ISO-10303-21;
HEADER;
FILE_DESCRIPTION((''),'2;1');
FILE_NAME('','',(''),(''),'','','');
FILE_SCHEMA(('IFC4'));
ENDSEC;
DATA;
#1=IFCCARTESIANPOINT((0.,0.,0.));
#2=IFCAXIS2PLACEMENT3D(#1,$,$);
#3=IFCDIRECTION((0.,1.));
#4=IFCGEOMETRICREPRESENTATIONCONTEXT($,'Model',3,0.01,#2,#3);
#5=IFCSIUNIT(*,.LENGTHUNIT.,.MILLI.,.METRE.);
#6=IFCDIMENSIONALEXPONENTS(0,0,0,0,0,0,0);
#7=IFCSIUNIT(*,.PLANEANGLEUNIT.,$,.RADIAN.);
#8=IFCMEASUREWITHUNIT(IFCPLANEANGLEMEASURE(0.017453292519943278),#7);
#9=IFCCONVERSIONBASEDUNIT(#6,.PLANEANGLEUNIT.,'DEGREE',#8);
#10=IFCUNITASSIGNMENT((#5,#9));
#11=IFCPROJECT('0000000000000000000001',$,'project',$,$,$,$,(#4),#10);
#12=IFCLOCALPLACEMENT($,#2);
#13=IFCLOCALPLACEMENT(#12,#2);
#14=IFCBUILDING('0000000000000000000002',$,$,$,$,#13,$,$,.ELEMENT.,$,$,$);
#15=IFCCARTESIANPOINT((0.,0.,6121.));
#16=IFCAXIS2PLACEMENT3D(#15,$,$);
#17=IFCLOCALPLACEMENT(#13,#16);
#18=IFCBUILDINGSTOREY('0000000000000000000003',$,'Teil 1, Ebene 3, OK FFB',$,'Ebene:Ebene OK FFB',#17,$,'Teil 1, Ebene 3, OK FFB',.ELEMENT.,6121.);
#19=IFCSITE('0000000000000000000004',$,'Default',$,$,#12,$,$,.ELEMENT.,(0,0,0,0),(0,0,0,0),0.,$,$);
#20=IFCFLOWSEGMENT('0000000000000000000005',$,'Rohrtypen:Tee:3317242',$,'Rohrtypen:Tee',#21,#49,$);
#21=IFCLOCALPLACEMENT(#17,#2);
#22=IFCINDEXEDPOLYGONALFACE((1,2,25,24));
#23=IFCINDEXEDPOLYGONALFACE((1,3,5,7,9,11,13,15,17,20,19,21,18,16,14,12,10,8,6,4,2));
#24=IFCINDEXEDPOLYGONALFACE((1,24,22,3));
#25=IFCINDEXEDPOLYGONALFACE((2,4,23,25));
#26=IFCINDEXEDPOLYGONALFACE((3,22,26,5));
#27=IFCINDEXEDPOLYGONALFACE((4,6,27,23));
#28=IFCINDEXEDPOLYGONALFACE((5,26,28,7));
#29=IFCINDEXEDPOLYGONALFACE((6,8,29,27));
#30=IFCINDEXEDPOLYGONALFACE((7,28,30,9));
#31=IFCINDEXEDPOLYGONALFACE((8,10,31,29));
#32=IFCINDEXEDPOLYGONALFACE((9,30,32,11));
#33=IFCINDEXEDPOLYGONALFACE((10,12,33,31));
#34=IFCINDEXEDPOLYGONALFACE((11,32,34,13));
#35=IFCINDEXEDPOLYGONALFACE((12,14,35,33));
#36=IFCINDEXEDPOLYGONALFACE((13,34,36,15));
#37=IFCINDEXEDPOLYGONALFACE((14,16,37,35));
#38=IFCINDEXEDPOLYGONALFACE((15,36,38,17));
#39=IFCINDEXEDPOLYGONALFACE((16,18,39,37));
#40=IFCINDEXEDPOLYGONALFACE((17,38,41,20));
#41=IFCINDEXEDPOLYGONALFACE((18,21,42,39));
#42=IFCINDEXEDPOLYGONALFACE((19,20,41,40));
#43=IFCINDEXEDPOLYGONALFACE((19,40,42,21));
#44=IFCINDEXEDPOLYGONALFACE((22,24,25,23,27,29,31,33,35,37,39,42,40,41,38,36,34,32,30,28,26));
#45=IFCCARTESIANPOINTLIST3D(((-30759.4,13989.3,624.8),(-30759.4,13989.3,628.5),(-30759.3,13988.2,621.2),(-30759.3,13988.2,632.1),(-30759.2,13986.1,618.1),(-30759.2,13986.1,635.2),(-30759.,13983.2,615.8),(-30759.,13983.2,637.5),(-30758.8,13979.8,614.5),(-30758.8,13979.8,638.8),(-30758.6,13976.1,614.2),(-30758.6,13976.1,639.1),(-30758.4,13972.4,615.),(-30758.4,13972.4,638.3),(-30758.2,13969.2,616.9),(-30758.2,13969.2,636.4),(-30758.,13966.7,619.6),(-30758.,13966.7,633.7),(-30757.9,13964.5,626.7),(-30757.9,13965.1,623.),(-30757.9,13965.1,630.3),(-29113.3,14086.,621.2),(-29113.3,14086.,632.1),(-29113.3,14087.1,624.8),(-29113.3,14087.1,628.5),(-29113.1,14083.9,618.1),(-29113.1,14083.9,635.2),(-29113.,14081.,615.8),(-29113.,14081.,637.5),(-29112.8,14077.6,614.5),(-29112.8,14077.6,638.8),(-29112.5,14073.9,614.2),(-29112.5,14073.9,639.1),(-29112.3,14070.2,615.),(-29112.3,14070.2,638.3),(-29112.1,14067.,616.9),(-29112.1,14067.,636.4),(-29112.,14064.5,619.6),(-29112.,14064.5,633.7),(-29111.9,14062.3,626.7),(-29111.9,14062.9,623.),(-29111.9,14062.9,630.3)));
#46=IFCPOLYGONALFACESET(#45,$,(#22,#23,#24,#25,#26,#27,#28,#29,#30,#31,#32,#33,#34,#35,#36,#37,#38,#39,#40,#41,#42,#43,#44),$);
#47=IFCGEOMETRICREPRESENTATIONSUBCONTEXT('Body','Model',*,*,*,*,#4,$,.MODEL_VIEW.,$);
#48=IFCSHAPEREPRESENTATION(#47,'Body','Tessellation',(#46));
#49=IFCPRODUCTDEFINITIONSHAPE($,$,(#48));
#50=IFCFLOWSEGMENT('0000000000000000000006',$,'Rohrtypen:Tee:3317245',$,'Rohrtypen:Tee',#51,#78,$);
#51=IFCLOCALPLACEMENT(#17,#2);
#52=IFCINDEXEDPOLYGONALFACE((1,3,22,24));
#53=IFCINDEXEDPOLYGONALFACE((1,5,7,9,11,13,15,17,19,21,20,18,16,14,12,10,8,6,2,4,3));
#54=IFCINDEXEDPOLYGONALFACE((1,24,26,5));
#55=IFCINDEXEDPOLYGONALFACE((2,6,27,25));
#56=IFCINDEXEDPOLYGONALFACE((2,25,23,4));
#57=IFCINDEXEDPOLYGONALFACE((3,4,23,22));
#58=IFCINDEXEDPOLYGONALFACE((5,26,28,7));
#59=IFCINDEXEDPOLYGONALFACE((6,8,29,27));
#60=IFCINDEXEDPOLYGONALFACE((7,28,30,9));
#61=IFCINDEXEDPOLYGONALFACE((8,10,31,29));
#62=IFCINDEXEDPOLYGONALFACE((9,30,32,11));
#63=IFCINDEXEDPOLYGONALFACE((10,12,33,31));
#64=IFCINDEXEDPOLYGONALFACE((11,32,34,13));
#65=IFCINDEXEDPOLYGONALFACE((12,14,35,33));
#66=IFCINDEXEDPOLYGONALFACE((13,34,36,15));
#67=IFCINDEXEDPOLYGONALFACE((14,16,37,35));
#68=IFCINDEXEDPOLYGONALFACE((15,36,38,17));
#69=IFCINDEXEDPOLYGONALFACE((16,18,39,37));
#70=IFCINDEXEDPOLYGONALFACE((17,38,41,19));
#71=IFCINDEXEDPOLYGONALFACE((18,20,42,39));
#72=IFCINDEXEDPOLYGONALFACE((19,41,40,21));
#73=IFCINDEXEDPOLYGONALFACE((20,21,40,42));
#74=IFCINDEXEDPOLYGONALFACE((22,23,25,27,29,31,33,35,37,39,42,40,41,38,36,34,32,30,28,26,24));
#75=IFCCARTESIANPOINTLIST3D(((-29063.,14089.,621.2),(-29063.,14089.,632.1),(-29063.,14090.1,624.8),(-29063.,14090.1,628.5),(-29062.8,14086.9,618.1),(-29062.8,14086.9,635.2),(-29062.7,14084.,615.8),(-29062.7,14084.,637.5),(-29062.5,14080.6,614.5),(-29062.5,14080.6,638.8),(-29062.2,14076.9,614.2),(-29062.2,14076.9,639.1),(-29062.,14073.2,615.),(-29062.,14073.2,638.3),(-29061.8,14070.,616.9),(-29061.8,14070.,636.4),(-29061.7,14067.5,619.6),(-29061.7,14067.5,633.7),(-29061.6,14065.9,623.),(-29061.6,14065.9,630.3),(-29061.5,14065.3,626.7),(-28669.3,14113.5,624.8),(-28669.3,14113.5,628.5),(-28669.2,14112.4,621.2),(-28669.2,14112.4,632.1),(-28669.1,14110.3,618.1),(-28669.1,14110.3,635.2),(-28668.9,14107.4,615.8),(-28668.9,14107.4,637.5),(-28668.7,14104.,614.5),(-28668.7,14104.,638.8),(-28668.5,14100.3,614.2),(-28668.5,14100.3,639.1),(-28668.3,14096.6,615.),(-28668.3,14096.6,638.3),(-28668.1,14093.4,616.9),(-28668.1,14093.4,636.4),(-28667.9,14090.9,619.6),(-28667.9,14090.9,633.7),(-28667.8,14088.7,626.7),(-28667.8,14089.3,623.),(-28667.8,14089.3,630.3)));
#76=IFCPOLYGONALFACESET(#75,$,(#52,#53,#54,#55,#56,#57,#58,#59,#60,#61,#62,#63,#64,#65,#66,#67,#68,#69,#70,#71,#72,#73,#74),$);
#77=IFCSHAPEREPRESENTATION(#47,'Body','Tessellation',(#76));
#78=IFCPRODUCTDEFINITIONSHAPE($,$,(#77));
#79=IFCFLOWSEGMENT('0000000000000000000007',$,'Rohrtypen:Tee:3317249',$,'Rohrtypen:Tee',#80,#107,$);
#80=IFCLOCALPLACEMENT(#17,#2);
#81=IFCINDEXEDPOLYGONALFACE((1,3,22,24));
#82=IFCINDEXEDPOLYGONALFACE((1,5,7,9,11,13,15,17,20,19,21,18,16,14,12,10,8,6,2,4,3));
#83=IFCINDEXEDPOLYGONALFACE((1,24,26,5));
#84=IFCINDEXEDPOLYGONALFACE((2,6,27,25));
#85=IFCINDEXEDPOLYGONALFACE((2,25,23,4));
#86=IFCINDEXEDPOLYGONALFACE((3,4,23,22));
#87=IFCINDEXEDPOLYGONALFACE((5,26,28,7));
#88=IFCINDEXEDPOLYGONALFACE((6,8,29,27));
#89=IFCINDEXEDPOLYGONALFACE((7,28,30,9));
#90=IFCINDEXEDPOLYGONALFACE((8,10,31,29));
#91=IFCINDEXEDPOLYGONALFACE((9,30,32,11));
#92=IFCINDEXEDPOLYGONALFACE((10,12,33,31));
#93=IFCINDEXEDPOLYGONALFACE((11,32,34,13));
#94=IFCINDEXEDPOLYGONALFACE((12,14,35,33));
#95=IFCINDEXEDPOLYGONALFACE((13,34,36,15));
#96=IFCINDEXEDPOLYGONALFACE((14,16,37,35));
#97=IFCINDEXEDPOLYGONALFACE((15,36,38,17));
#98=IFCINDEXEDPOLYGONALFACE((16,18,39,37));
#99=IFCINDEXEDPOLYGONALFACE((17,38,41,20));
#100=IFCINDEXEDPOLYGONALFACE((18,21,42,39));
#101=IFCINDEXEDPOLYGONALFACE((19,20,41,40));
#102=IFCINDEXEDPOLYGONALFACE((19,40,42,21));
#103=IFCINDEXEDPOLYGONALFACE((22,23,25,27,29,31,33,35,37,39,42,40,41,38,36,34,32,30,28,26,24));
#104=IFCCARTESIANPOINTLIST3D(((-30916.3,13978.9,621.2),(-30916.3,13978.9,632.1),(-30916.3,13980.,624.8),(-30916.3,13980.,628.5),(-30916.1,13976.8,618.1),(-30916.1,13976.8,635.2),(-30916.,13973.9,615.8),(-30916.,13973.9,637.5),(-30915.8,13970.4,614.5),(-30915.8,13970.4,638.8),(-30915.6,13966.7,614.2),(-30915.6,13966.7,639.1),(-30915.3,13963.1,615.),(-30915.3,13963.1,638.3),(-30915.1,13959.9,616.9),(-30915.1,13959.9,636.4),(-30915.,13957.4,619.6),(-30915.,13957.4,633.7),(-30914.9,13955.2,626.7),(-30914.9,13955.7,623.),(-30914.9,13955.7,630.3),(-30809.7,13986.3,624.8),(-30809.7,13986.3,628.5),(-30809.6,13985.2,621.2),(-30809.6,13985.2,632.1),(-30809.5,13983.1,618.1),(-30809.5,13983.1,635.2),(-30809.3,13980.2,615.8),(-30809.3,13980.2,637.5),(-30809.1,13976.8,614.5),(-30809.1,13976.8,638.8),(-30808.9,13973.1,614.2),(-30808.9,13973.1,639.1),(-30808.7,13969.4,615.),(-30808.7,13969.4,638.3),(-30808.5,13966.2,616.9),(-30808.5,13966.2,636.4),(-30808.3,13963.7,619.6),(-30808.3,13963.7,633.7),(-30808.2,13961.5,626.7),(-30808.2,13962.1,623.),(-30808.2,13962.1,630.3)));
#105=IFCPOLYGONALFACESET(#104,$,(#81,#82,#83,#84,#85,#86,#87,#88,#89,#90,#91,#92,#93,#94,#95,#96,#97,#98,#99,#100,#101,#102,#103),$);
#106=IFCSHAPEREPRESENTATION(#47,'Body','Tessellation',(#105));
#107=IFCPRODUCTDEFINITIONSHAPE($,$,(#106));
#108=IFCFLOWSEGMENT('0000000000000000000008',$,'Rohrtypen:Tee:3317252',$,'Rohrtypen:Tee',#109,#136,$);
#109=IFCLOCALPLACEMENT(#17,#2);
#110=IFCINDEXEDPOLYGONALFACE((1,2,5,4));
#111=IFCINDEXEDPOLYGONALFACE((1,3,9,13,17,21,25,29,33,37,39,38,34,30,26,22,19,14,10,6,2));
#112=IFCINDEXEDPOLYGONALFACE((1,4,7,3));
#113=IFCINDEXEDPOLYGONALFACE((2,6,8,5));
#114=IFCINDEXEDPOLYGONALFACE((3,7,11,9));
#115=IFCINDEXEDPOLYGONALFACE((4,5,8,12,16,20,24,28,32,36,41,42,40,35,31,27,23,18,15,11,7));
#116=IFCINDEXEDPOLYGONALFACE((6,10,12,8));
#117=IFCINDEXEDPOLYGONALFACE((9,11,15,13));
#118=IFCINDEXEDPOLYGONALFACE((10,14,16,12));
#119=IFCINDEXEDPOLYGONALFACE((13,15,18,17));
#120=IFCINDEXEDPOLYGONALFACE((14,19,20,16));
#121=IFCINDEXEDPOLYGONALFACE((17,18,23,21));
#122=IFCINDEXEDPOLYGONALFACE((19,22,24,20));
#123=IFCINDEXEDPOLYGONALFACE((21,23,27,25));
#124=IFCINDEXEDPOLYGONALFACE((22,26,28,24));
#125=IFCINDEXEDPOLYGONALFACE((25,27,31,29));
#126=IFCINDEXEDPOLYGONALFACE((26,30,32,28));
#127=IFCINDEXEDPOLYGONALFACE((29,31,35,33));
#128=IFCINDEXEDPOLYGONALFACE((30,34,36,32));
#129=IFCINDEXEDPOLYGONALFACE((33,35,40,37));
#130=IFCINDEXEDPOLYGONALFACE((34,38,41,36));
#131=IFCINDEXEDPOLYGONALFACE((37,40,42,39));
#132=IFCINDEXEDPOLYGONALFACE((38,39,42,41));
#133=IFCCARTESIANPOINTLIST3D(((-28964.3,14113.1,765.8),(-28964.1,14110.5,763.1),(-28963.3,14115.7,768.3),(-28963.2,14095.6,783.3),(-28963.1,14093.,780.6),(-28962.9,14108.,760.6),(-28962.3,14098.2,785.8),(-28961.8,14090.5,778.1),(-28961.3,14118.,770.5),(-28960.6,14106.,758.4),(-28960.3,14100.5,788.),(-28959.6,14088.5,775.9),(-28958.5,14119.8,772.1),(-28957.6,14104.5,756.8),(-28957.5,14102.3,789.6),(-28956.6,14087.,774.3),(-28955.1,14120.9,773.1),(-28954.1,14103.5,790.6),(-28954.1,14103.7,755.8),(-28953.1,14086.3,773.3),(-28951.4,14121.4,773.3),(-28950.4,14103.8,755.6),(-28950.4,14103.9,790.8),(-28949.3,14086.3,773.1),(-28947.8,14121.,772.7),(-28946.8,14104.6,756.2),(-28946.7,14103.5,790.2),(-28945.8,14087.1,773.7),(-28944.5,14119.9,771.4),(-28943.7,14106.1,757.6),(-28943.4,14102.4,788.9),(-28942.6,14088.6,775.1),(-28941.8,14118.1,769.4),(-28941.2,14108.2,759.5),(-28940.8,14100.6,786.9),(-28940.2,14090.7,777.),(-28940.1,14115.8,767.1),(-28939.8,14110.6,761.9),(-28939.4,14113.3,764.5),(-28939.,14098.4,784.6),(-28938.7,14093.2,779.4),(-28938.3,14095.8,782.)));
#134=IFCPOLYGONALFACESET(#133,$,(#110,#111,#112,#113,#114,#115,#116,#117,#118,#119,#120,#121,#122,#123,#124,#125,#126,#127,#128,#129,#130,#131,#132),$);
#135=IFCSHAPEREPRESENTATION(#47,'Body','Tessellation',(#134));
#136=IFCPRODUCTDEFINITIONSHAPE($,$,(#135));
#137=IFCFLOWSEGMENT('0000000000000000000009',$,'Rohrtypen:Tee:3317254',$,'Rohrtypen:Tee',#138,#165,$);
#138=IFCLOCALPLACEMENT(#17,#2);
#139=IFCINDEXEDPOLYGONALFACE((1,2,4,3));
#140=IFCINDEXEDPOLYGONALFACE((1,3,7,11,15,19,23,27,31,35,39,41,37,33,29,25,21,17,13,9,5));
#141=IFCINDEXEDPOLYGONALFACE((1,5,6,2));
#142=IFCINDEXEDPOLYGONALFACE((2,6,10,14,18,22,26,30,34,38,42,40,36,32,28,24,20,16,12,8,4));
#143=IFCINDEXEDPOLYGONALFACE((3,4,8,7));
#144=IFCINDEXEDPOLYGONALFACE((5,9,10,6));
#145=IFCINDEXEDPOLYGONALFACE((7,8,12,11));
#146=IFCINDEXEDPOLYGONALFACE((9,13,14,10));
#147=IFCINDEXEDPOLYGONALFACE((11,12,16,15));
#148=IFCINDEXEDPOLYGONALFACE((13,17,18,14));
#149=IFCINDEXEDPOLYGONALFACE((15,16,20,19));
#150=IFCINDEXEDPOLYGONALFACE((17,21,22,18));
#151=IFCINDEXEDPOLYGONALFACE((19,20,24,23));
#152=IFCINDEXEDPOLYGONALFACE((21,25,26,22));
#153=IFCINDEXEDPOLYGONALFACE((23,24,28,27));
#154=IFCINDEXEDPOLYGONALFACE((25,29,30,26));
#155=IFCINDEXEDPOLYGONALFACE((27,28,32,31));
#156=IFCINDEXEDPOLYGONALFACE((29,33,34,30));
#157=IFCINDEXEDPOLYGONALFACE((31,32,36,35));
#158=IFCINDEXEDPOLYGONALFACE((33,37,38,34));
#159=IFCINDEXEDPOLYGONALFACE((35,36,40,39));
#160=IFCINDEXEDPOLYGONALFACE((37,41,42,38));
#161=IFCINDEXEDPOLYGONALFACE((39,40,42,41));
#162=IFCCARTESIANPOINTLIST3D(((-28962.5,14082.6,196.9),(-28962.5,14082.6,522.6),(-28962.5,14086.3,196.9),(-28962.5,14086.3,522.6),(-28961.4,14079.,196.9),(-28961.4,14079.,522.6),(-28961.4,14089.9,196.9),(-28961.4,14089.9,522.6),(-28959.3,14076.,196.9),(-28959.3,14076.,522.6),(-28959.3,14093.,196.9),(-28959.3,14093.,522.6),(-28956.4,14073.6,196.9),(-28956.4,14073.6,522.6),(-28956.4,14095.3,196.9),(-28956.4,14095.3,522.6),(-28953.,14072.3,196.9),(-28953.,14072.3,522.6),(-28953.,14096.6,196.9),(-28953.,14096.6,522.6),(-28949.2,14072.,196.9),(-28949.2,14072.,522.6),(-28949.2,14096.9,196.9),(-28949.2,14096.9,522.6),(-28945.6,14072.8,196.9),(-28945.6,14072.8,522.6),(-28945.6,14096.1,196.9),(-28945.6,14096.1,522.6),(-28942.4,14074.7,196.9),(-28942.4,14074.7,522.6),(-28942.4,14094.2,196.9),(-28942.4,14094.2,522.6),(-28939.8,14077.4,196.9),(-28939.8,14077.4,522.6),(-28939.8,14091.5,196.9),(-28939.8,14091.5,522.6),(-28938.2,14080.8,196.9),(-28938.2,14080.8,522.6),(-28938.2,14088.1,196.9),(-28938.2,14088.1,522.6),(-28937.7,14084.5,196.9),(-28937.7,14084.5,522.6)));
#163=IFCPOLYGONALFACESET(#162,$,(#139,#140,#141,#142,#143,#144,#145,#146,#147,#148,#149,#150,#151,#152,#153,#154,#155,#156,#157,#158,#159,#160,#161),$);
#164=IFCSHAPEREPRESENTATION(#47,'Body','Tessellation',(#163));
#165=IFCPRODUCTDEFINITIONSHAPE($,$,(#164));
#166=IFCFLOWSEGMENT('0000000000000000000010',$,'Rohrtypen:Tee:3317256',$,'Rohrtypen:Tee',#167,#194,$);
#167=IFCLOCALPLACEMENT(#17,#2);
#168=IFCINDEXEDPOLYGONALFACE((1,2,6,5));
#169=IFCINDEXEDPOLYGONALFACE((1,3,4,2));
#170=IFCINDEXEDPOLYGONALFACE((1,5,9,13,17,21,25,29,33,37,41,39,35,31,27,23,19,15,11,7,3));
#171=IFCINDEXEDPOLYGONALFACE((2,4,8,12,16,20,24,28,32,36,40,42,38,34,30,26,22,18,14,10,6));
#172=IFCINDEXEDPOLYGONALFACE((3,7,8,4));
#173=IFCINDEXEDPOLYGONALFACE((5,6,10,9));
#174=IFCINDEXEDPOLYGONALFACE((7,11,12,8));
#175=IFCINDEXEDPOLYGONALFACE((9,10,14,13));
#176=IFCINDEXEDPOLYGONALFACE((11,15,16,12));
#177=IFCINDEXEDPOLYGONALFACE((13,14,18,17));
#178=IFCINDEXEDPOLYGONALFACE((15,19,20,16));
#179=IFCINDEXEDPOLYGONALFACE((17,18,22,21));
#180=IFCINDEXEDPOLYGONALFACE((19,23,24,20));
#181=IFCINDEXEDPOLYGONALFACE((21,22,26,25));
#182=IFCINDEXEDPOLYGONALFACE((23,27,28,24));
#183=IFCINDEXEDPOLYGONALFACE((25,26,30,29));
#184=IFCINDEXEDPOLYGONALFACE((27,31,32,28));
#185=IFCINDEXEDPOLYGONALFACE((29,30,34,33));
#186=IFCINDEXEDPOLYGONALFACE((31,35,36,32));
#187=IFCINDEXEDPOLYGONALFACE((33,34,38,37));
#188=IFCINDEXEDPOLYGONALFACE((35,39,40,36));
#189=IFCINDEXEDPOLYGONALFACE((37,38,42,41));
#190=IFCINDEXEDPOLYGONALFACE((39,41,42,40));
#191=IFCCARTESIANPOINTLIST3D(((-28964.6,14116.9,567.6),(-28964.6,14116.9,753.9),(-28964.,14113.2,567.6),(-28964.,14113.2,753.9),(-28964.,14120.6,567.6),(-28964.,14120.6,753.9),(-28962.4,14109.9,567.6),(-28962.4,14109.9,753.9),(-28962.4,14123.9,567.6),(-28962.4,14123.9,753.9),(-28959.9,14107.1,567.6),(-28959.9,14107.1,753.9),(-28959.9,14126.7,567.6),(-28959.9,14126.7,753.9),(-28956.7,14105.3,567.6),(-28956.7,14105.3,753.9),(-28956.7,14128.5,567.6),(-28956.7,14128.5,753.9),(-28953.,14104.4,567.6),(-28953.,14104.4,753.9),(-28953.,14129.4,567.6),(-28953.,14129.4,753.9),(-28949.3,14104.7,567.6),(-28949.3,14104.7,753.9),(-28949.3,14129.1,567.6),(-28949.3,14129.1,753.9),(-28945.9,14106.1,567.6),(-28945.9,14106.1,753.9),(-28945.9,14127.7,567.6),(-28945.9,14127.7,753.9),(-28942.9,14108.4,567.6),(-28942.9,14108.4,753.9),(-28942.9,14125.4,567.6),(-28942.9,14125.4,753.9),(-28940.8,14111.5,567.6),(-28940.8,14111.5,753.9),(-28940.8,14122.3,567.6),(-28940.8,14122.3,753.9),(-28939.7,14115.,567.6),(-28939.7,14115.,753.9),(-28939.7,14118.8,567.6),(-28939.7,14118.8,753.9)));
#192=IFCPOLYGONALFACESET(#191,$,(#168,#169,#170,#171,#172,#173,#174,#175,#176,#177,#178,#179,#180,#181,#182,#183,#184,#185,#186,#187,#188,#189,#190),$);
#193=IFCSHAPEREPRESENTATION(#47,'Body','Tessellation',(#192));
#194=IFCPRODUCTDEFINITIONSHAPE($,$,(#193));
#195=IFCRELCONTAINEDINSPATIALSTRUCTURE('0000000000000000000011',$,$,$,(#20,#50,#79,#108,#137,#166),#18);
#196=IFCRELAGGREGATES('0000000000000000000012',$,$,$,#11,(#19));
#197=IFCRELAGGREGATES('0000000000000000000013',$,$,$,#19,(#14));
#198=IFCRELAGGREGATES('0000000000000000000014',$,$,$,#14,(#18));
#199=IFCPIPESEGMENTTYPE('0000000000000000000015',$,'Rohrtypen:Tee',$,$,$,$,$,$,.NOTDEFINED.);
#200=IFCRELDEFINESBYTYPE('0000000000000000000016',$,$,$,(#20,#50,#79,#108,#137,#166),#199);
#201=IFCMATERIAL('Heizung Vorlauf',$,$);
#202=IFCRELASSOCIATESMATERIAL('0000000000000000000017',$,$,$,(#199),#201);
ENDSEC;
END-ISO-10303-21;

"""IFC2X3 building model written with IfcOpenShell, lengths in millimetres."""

from ifc_helpers import new_model, entity, si_unit, converted_unit, direction, frame, frame_2d, origin, origin_2d_with_axis, place, context, subcontext, project, spatial, circle, extrude, material, type_object, element, save


model = new_model("IFC2X3")

# Units and contexts
model_context = context("Model", 3, precision=0.01, world=origin(), true_north=direction((0.0, 1.0)))
body_context = subcontext(model_context, "Body", "Model", "MODEL_VIEW")
ifc_project = project(units=[si_unit("LENGTHUNIT", "METRE", prefix="MILLI"), converted_unit("PLANEANGLEUNIT", "DEGREE", entity("IfcPlaneAngleMeasure", 0.017453292519943278), si_unit("PLANEANGLEUNIT", "RADIAN"), dimensions=[0, 0, 0, 0, 0, 0, 0])], contexts=[model_context])

# Site, building, storey
site_placement = place(None, origin())
site = spatial("IfcSite", under=ifc_project, at=site_placement, Name="Default", CompositionType="ELEMENT", RefLatitude=(0, 0, 0, 0), RefLongitude=(0, 0, 0, 0), RefElevation=0.0)
building_placement = place(site_placement, origin())
building = spatial("IfcBuilding", under=site, at=building_placement, CompositionType="ELEMENT")
storey_placement = place(building_placement, frame((0.0, 0.0, 6121.0)))
storey = spatial("IfcBuildingStorey", under=building, at=storey_placement, Name="Teil 1, Ebene 3, OK FFB", ObjectType="Ebene:Ebene OK FFB", LongName="Teil 1, Ebene 3, OK FFB", CompositionType="ELEMENT", Elevation=6121.0)

# Flow segments
ifc_material = material(Name="Heizung Vorlauf")
pipe_segment_type = type_object("IfcPipeSegmentType", Name="Rohrtypen:Tee", PredefinedType="NOTDEFINED", material=ifc_material)
flow_segment_1_placement = place(storey_placement, origin())
element("IfcFlowSegment", 1, at=flow_segment_1_placement, inside=storey, type_object=pipe_segment_type, Name="Rohrtypen:Tee:3317242", ObjectType="Rohrtypen:Tee", context=body_context, shape_type="SweptSolid", body=[
    extrude(circle(Radius=12.5, at=origin_2d_with_axis()), frame((-30758.6, 13977.0, 626.7), z_axis=(0.998239, 0.059319, 0.0), x_axis=(0.059319, -0.998239, 0.0)), (0.0, 0.0, 1.0), 1648.9),
])
flow_segment_2_placement = place(storey_placement, origin())
element("IfcFlowSegment", 2, at=flow_segment_2_placement, inside=storey, type_object=pipe_segment_type, Name="Rohrtypen:Tee:3317245", ObjectType="Rohrtypen:Tee", context=body_context, shape_type="SweptSolid", body=[
    extrude(circle(Radius=12.5, at=origin_2d_with_axis()), frame((-29062.3, 14077.8, 626.7), z_axis=(0.998239, 0.059319, 0.0), x_axis=(0.059319, -0.998239, 0.0)), (0.0, 0.0, 1.0), 394.5),
])
flow_segment_3_placement = place(storey_placement, origin())
element("IfcFlowSegment", 3, at=flow_segment_3_placement, inside=storey, type_object=pipe_segment_type, Name="Rohrtypen:Tee:3317249", ObjectType="Rohrtypen:Tee", context=body_context, shape_type="SweptSolid", body=[
    extrude(circle(Radius=12.5, at=frame_2d((0.0, 0.0), x_axis=(1.0, 0.0))), frame((-30915.6, 13967.7, 626.7), z_axis=(0.998239, 0.059319, 0.0), x_axis=(0.059319, -0.998239, 0.0)), (0.0, 0.0, 1.0), 106.9),
])
flow_segment_4_placement = place(storey_placement, origin())
element("IfcFlowSegment", 4, at=flow_segment_4_placement, inside=storey, type_object=pipe_segment_type, Name="Rohrtypen:Tee:3317252", ObjectType="Rohrtypen:Tee", context=body_context, shape_type="SweptSolid", body=[
    extrude(circle(Radius=12.5, at=frame_2d((0.0, 0.0), x_axis=(1.0, 0.0))), frame((-28951.8, 14112.5, 764.5), z_axis=(0.041945, -0.705862, 0.707107), x_axis=(0.998239, 0.059319, 0.0)), (0.0, 0.0, 1.0), 24.7),
])
flow_segment_5_placement = place(storey_placement, origin())
element("IfcFlowSegment", 5, at=flow_segment_5_placement, inside=storey, type_object=pipe_segment_type, Name="Rohrtypen:Tee:3317254", ObjectType="Rohrtypen:Tee", context=body_context, shape_type="SweptSolid", body=[
    extrude(circle(Radius=12.5, at=frame_2d((0.0, 0.0), x_axis=(1.0, 0.0))), frame((-28950.2, 14084.5, 196.9)), (0.0, 0.0, 1.0), 325.8),
])
flow_segment_6_placement = place(storey_placement, origin())
element("IfcFlowSegment", 6, at=flow_segment_6_placement, inside=storey, type_object=pipe_segment_type, Name="Rohrtypen:Tee:3317256", ObjectType="Rohrtypen:Tee", context=body_context, shape_type="SweptSolid", body=[
    extrude(circle(Radius=12.5, at=frame_2d((0.0, 0.0), x_axis=(1.0, 0.0))), frame((-28952.1, 14116.9, 567.6), z_axis=(0.0, 0.0, 1.0), x_axis=(-1.0, 0.0, 0.0)), (0.0, 0.0, 1.0), 186.3),
])

save(model, "model.ifc")
